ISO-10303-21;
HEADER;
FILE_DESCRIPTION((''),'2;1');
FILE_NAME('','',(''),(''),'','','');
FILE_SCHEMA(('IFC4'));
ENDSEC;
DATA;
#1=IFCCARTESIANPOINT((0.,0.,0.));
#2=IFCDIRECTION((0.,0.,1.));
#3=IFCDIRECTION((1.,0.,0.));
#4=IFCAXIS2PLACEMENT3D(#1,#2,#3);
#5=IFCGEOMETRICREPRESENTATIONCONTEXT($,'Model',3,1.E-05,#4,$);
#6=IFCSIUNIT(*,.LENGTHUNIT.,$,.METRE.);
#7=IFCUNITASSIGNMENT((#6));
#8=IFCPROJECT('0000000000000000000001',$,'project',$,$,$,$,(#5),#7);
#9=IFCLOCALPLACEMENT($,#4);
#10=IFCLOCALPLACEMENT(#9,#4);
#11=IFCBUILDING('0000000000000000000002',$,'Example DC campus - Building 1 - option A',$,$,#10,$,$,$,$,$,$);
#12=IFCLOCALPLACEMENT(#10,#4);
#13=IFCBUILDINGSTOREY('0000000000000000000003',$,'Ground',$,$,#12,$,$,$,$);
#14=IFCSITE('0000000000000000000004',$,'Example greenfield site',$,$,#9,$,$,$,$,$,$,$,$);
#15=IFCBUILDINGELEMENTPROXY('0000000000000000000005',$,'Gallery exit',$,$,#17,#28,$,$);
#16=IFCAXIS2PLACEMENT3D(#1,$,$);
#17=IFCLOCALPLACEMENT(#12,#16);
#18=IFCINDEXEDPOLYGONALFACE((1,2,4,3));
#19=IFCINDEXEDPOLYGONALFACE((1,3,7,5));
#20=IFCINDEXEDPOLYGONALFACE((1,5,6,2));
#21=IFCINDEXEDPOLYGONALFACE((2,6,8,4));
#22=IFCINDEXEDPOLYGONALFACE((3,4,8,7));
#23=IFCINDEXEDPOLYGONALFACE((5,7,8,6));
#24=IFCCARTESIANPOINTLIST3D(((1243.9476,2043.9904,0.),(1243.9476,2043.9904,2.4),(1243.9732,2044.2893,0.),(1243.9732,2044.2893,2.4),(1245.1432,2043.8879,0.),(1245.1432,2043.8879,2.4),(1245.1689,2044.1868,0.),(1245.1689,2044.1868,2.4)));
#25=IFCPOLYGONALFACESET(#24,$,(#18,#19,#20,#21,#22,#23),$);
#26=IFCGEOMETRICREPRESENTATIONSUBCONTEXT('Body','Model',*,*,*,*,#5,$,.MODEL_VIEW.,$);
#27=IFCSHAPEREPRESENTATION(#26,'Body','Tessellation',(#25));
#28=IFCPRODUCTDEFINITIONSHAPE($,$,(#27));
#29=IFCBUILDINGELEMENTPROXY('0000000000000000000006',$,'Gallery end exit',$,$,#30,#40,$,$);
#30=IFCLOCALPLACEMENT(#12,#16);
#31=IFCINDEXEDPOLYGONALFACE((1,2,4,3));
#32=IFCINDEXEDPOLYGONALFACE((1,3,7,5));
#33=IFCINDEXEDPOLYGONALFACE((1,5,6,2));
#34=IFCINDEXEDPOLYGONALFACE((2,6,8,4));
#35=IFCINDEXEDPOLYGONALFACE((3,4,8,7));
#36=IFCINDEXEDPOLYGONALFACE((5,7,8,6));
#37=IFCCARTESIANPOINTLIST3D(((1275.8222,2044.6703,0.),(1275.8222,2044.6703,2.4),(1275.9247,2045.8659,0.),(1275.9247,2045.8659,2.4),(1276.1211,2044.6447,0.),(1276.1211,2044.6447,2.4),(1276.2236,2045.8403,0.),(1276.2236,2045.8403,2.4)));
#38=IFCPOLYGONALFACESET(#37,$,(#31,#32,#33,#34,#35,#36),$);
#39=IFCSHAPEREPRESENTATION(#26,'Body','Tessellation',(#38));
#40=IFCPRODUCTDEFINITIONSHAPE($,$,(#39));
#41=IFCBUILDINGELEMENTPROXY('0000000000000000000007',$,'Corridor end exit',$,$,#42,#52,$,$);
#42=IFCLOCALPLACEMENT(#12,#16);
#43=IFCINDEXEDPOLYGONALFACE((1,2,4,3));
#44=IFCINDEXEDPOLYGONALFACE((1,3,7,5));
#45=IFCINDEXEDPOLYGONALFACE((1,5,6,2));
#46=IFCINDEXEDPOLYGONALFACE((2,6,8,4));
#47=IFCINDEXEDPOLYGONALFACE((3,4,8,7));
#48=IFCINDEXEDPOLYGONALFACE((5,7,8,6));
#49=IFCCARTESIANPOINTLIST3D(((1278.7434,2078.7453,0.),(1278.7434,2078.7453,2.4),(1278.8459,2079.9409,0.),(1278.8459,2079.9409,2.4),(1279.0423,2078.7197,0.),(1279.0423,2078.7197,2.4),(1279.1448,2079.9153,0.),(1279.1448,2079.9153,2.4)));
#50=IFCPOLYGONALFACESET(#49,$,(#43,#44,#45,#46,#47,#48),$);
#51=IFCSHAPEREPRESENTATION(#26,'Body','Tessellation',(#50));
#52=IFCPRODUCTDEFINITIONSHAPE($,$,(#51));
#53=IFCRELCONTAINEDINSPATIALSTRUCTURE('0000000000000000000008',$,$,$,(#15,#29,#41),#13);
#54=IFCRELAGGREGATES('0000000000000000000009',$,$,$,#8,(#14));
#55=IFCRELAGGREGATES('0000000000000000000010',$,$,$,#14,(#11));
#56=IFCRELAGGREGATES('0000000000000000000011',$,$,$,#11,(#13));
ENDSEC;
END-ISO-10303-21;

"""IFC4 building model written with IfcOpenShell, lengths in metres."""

from ifc_helpers import new_model, si_unit, frame, origin_with_axes, place, context, subcontext, project, spatial, line, indexed_curve, outline, extrude, element, save


model = new_model("IFC4")

# Units and contexts
model_context = context("Model", 3, precision=1e-05, world=origin_with_axes())
body_context = subcontext(model_context, "Body", "Model", "MODEL_VIEW")
ifc_project = project(units=[si_unit("LENGTHUNIT", "METRE")], contexts=[model_context])

# Site, building, storey
site_placement = place(None, origin_with_axes())
site = spatial("IfcSite", under=ifc_project, at=site_placement, Name="Example greenfield site")
building_placement = place(site_placement, origin_with_axes())
building = spatial("IfcBuilding", under=site, at=building_placement, Name="Example DC campus - Building 1 - option A")
storey_placement = place(building_placement, origin_with_axes())
storey = spatial("IfcBuildingStorey", under=building, at=storey_placement, Name="Ground")

# Building element proxies
for number, where, z_axis, x_axis, name in (
    (1, (1243.9476, 2043.9904, 0.0), (0.0, 0.0, 1.0), (0.996345, -0.085417, 0.0), "Gallery exit"),
):
    element("IfcBuildingElementProxy", number, at=place(storey_placement, frame(where, z_axis=z_axis, x_axis=x_axis)), inside=storey, Name=name, context=body_context, shape_type="SweptSolid", body=[
        extrude(outline(indexed_curve([(0.0, 0.0), (1.2, 0.0), (1.2, 0.3), (0.0, 0.3)], segments=[line(1, 2, 3, 4, 1)])), origin_with_axes(), (0.0, 0.0, 1.0), 2.4),
    ])
for number, where, z_axis, x_axis, name in (
    (2, (1275.8222, 2044.6703, 0.0), (0.0, 0.0, 1.0), (0.996345, -0.085417, 0.0), "Gallery end exit"),
    (3, (1278.7434, 2078.7453, 0.0), (0.0, 0.0, 1.0), (0.996345, -0.085417, 0.0), "Corridor end exit"),
):
    element("IfcBuildingElementProxy", number, at=place(storey_placement, frame(where, z_axis=z_axis, x_axis=x_axis)), inside=storey, Name=name, context=body_context, shape_type="SweptSolid", body=[
        extrude(outline(indexed_curve([(0.0, 0.0), (0.3, 0.0), (0.3, 1.2), (0.0, 1.2)], segments=[line(1, 2, 3, 4, 1)])), origin_with_axes(), (0.0, 0.0, 1.0), 2.4),
    ])

save(model, "model.ifc")
